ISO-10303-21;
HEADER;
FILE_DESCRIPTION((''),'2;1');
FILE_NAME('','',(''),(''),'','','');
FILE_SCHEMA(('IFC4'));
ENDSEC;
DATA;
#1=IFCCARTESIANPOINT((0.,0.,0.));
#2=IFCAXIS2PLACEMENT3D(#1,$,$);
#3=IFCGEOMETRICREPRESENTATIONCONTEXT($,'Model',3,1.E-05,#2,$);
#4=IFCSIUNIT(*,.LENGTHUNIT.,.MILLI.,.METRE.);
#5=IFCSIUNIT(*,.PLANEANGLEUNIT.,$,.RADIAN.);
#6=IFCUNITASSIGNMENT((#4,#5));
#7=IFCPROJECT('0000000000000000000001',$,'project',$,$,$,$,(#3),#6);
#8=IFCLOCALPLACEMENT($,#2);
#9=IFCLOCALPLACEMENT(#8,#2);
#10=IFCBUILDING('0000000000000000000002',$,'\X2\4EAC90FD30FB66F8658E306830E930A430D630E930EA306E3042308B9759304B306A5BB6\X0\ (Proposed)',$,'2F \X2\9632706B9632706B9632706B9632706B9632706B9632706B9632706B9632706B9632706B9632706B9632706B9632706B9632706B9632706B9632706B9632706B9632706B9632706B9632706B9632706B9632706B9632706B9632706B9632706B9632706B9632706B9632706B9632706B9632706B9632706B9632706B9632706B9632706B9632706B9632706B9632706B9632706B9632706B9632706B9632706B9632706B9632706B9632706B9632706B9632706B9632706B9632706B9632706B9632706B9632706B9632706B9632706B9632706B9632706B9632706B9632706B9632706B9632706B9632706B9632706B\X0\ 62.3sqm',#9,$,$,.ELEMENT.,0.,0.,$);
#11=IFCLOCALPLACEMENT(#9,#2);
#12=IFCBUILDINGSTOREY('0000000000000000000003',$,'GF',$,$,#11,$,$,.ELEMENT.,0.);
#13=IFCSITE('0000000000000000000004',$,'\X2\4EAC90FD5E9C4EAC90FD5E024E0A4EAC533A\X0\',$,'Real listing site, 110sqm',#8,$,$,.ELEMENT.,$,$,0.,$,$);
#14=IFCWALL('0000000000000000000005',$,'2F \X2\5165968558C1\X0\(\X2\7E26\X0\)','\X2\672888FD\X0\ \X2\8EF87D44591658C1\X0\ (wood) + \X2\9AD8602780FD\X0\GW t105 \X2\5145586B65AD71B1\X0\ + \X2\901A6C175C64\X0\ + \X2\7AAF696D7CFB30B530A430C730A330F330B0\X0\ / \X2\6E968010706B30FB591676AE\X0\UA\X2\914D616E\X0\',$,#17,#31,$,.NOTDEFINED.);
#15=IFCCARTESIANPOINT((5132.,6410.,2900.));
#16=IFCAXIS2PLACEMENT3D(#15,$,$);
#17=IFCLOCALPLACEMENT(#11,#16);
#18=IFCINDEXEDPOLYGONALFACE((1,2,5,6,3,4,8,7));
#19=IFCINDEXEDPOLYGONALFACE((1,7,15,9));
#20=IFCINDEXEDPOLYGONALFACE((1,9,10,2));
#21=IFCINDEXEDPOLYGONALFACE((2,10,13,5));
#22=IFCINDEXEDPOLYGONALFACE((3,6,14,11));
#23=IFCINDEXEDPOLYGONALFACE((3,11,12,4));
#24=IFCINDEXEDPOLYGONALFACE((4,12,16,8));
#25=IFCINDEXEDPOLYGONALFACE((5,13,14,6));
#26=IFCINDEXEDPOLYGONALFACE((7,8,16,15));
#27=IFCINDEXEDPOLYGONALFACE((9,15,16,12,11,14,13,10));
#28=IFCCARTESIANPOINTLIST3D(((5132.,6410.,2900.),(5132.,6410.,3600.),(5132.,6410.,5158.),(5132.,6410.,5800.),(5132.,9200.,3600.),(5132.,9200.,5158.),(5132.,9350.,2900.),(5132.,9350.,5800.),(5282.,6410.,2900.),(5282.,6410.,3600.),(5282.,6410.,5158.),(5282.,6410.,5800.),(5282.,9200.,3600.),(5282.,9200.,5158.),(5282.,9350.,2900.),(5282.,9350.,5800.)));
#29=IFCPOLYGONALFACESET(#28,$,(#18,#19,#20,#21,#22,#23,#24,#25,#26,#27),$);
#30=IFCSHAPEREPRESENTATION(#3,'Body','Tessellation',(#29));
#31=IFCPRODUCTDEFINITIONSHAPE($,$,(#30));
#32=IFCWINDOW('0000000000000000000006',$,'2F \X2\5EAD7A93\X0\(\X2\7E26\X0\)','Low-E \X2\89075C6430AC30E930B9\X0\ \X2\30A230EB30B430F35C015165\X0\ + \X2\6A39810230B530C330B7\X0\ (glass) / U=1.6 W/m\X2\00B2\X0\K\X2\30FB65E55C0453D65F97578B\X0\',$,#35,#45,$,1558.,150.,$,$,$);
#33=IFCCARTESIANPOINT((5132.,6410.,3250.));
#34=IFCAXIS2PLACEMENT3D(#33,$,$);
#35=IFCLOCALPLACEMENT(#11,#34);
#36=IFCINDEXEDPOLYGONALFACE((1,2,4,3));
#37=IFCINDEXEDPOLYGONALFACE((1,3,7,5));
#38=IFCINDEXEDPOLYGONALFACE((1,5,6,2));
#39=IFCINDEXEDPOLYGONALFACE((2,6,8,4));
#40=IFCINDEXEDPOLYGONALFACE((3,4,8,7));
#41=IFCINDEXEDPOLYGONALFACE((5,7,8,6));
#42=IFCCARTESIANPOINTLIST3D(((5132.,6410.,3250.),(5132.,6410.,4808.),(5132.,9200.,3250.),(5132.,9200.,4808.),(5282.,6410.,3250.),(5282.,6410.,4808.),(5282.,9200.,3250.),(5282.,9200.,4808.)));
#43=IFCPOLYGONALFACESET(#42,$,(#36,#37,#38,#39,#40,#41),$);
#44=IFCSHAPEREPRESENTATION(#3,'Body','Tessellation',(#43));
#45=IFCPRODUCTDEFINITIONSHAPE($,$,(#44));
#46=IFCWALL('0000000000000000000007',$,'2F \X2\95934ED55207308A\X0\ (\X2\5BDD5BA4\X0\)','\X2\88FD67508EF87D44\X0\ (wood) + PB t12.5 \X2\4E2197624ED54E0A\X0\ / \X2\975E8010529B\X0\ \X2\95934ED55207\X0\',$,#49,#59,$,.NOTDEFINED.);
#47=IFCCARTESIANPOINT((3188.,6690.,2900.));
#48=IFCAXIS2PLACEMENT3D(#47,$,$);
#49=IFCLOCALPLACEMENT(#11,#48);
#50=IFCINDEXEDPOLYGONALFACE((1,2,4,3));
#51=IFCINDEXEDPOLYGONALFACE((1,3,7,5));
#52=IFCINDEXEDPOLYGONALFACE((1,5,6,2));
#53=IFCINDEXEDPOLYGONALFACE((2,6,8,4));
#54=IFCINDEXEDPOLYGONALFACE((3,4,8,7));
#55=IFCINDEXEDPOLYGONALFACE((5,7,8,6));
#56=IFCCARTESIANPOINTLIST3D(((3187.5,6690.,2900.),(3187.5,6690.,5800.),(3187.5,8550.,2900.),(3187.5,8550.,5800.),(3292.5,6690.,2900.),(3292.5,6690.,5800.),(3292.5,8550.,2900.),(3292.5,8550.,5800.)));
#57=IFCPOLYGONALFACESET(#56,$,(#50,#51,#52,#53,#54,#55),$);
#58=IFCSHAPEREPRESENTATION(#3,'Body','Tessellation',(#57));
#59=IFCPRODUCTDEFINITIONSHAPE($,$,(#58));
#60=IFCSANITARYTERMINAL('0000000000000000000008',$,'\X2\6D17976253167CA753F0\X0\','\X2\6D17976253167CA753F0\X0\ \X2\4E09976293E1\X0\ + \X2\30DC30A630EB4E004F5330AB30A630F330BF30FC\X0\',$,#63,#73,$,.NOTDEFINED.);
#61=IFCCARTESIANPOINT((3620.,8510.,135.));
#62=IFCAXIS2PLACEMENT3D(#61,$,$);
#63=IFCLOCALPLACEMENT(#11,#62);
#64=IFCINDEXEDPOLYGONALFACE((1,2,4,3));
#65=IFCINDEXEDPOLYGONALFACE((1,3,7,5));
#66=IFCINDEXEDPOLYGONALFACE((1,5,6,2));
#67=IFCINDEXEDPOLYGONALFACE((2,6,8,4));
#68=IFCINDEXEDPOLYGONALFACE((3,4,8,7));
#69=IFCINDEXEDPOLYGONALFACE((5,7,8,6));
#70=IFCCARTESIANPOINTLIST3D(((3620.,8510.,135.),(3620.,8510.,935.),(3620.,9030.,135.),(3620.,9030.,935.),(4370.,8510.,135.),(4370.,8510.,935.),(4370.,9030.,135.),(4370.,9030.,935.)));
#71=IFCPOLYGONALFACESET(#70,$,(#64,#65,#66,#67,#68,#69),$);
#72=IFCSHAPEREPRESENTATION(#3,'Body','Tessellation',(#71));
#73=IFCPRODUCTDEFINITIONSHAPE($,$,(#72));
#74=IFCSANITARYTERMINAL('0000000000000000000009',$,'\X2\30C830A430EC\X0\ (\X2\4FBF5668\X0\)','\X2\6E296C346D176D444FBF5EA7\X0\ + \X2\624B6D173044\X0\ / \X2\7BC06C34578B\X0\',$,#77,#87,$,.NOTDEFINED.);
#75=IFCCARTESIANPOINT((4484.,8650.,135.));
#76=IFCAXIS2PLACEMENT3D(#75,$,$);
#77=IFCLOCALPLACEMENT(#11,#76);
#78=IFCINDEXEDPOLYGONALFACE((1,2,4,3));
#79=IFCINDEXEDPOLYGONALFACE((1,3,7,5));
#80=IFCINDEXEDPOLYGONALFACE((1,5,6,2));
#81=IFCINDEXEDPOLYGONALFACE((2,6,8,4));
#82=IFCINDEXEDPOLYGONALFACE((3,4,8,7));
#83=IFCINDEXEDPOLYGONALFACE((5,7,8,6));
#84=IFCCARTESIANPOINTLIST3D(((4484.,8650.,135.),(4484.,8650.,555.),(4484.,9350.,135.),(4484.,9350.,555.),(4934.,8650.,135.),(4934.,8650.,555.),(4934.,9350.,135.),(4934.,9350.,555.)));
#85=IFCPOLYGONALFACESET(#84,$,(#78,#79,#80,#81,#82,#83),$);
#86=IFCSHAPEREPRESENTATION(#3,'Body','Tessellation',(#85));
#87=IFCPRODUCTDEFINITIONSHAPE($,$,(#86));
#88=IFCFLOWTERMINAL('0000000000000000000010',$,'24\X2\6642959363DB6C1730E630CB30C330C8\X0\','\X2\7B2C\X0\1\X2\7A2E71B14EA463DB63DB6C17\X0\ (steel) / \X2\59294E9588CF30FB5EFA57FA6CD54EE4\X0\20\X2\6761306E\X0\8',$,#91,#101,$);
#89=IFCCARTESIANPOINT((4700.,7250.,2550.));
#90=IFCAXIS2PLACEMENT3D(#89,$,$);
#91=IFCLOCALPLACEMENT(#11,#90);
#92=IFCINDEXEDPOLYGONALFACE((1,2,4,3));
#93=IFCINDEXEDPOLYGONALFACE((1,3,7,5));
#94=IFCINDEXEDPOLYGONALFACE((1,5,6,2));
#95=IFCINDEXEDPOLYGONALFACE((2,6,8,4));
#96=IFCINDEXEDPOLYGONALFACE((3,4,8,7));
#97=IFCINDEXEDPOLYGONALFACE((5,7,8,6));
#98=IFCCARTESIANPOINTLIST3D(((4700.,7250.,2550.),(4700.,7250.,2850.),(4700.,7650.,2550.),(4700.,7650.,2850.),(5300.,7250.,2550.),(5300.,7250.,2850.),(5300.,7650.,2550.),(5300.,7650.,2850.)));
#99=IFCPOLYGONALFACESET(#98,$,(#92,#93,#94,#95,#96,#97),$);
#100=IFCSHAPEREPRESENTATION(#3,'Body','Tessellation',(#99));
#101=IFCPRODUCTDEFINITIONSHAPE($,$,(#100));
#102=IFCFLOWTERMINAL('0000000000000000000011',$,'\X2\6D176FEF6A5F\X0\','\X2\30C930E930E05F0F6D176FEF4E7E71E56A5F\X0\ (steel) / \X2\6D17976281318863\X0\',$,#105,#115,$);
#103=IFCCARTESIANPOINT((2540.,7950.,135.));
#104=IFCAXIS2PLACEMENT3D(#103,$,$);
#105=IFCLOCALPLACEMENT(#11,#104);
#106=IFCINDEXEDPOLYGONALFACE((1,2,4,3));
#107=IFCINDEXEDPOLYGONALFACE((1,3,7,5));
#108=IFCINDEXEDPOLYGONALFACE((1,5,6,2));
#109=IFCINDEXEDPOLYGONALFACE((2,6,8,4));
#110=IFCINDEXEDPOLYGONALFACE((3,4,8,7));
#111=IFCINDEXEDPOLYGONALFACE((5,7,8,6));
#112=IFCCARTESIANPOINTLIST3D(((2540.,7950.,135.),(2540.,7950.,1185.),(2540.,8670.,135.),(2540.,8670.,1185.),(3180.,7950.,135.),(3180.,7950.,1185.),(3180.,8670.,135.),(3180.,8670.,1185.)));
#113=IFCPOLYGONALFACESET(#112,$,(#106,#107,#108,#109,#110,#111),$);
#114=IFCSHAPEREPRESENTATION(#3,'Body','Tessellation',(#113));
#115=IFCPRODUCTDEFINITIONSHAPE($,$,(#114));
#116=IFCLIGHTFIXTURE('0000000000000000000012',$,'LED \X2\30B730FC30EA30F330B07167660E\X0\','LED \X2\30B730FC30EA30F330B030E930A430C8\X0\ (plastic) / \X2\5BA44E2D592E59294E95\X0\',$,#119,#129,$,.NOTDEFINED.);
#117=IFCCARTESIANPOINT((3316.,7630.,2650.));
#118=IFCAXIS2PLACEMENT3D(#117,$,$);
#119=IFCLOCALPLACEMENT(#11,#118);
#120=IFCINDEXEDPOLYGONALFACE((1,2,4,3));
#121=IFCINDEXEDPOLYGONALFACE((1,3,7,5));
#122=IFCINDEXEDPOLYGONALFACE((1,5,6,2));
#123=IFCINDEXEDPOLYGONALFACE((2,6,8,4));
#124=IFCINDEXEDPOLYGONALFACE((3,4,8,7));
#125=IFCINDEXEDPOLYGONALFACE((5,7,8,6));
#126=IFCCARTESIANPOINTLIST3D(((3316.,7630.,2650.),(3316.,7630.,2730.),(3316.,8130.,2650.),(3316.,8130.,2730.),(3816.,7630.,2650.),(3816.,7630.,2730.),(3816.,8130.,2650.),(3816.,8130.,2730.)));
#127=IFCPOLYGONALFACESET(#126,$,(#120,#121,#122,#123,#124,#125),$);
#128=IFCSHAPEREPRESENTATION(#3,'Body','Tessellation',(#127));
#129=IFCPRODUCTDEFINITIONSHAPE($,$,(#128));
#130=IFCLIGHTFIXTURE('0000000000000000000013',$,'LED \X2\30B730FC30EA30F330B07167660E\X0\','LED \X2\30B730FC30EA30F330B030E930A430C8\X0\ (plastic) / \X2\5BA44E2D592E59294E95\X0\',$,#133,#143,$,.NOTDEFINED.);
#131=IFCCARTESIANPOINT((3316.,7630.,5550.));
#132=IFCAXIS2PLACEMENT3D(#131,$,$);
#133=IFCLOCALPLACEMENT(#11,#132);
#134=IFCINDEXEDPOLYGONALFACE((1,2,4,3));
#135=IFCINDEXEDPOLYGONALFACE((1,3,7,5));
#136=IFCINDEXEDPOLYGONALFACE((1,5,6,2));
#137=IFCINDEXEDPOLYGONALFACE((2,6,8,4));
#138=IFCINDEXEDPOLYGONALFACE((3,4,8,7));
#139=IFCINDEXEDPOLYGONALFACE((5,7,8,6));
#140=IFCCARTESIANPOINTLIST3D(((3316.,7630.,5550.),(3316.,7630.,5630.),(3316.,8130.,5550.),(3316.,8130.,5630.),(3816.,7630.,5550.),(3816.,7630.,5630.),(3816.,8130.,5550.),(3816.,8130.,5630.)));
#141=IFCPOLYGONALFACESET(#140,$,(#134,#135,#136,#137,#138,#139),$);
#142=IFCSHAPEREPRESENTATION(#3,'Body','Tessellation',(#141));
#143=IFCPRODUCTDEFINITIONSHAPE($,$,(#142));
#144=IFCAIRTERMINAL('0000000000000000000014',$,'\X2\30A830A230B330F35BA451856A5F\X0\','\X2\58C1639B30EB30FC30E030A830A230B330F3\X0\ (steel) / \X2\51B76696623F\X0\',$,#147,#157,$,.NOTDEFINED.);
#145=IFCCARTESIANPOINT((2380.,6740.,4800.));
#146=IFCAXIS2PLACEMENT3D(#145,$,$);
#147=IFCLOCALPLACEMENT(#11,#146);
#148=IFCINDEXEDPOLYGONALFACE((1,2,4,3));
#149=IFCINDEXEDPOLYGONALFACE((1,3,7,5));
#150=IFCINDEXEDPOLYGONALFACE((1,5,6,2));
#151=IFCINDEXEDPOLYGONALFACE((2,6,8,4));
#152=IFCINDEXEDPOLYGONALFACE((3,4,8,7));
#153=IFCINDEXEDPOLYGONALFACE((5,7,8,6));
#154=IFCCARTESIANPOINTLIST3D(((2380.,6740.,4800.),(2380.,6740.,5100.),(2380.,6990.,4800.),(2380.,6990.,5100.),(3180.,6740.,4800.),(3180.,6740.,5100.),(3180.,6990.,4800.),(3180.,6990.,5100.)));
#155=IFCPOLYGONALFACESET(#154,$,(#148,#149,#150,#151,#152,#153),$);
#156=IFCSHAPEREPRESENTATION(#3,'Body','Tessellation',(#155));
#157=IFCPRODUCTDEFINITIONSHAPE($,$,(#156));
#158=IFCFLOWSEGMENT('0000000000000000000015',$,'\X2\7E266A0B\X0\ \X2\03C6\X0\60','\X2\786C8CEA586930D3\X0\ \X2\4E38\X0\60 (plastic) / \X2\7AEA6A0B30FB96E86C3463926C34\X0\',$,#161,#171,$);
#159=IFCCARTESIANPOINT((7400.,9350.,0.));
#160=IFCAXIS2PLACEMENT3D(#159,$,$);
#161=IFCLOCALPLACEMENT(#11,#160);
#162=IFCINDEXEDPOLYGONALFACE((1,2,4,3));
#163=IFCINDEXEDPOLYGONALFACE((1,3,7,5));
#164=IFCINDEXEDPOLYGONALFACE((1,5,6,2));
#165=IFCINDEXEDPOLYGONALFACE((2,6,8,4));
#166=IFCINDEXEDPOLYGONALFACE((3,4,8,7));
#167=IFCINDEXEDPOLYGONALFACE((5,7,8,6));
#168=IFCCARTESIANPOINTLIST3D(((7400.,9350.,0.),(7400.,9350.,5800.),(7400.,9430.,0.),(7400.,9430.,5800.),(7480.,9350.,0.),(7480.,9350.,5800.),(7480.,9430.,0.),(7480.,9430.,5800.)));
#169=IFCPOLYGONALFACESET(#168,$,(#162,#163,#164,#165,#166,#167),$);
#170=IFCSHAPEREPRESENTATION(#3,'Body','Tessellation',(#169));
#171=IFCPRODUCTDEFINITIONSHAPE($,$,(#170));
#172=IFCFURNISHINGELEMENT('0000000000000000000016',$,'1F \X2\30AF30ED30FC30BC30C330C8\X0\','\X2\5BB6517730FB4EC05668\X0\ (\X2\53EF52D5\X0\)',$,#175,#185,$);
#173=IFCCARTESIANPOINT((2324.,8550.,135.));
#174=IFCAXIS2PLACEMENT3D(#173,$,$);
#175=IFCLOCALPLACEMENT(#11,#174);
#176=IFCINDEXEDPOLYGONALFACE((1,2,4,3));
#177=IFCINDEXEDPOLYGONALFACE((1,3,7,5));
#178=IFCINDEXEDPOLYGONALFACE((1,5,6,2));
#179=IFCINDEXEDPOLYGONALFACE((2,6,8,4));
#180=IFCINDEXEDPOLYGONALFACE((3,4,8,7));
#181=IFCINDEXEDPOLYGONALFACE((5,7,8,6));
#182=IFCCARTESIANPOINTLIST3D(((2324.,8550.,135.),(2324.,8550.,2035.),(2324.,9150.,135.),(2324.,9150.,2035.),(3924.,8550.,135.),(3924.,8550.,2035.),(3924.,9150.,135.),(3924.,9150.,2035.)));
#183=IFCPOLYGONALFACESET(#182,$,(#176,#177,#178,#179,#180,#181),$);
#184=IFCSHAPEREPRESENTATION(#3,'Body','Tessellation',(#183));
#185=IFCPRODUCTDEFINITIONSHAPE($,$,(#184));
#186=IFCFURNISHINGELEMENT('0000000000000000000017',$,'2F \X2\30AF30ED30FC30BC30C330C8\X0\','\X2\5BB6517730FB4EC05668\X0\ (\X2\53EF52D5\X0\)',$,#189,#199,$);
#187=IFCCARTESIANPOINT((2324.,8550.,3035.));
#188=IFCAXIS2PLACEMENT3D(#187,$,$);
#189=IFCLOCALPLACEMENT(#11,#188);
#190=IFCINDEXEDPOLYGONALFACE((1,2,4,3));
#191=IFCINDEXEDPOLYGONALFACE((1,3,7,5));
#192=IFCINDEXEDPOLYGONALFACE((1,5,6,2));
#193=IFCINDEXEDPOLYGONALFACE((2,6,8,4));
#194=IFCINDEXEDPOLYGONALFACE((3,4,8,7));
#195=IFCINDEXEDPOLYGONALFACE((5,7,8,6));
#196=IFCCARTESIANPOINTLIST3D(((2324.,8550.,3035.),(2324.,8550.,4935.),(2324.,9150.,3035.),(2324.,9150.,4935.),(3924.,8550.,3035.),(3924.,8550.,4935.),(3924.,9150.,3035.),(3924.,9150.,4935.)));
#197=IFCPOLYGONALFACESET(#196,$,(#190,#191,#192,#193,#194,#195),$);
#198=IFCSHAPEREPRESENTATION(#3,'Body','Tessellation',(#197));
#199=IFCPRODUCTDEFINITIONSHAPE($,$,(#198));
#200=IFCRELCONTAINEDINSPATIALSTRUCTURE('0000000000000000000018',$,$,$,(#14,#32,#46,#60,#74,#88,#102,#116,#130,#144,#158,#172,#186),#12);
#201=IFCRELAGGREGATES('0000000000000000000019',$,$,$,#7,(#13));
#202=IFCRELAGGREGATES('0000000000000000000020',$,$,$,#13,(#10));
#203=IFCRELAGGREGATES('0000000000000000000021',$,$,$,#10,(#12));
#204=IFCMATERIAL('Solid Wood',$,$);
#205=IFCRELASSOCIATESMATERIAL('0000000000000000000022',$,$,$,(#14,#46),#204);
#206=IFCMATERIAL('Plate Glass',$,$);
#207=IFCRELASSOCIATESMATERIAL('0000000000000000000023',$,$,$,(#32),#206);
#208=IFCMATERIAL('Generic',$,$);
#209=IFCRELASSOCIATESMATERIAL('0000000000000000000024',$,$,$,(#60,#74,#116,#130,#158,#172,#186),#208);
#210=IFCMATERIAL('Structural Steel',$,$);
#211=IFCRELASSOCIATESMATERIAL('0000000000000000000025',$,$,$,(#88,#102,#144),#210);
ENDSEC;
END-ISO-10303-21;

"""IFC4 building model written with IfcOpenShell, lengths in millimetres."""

from ifc_helpers import new_model, si_unit, frame, frame_2d, origin, place, context, project, spatial, rectangle, extrude, material, element, fill, save


model = new_model("IFC4")

# Units and contexts
model_context = context("Model", 3, precision=1e-05, world=origin())
ifc_project = project(units=[si_unit("LENGTHUNIT", "METRE", prefix="MILLI"), si_unit("PLANEANGLEUNIT", "RADIAN")], contexts=[model_context])

# Site, building, storey
site_placement = place(None, origin())
site = spatial("IfcSite", under=ifc_project, at=site_placement, Name="京都府京都市上京区", ObjectType="Real listing site, 110sqm", CompositionType="ELEMENT", RefElevation=0.0)
building_placement = place(site_placement, origin())
building = spatial("IfcBuilding", under=site, at=building_placement, Name="京都・書斎とライブラリのある静かな家 (Proposed)", ObjectType="2F 防火防火防火防火防火防火防火防火防火防火防火防火防火防火防火防火防火防火防火防火防火防火防火防火防火防火防火防火防火防火防火防火防火防火防火防火防火防火防火防火防火防火防火防火防火防火防火防火防火防火防火防火防火防火防火防火防火防火防火防火 62.3sqm", CompositionType="ELEMENT", ElevationOfRefHeight=0.0, ElevationOfTerrain=0.0)
storey_placement = place(building_placement, origin())
storey = spatial("IfcBuildingStorey", under=building, at=storey_placement, Name="GF", CompositionType="ELEMENT", Elevation=0.0)

# Shared definitions
ifc_material_1 = material(Name="Solid Wood")

# Shared definitions
ifc_material_2 = material(Name="Plate Glass")

# Wall, opening, window
wall_1_placement = place(storey_placement, frame((5132.0, 6410.0, 2900.0)))
wall_1 = element("IfcWall", 1, at=wall_1_placement, inside=storey, material=ifc_material_1, Name="2F 入隅壁(縦)", Description="木製 軸組外壁 (wood) + 高性能GW t105 充填断熱 + 通気層 + 窯業系サイディング / 準耐火・外皮UA配慮", PredefinedType="NOTDEFINED", context=model_context, shape_type="SweptSolid", body=[
    extrude(rectangle(XDim=150.0, YDim=2940.0, at=frame_2d((75.0, 1470.0))), frame((5132.0, 6410.0, 2900.0)), (0.0, 0.0, 1.0), 2900.0),
])
opening_1_placement = place(storey_placement, frame((5132.0, 6410.0, 3250.0)))
opening_1 = element("IfcOpeningElement", 2, at=opening_1_placement, cuts=wall_1, PredefinedType="NOTDEFINED", context=model_context, shape_type="SweptSolid", body=[
    extrude(rectangle(XDim=150.0, YDim=2790.0, at=frame_2d((75.0, 1395.0))), frame((5132.0, 6410.0, 3250.0)), (0.0, 0.0, 1.0), 1558.0),
])
window_1_placement = place(storey_placement, frame((5132.0, 6410.0, 3250.0)))
window_1 = element("IfcWindow", 3, at=window_1_placement, inside=storey, material=ifc_material_2, Name="2F 庭窓(縦)", Description="Low-E 複層ガラス アルゴン封入 + 樹脂サッシ (glass) / U=1.6 W/m²K・日射取得型", OverallHeight=1558.0, OverallWidth=150.0, context=model_context, shape_type="SweptSolid", body=[
    extrude(rectangle(XDim=150.0, YDim=2790.0, at=frame_2d((75.0, 1395.0))), frame((5132.0, 6410.0, 3250.0)), (0.0, 0.0, 1.0), 1558.0),
])
fill(opening_1, window_1)

# Wall
wall_2_placement = place(storey_placement, frame((3188.0, 6690.0, 2900.0)))
element("IfcWall", 4, at=wall_2_placement, inside=storey, material=ifc_material_1, Name="2F 間仕切り (寝室)", Description="製材軸組 (wood) + PB t12.5 両面仕上 / 非耐力 間仕切", PredefinedType="NOTDEFINED", context=model_context, shape_type="SweptSolid", body=[
    extrude(rectangle(XDim=105.0, YDim=1860.0, at=frame_2d((52.0, 930.0))), frame((3188.0, 6690.0, 2900.0)), (0.0, 0.0, 1.0), 2900.0),
])

# Sanitary terminals
ifc_material_3 = material(Name="Generic")
sanitary_terminal_1_placement = place(storey_placement, frame((3620.0, 8510.0, 135.0)))
element("IfcSanitaryTerminal", 5, at=sanitary_terminal_1_placement, inside=storey, material=ifc_material_3, Name="洗面化粧台", Description="洗面化粧台 三面鏡 + ボウル一体カウンター", PredefinedType="NOTDEFINED", context=model_context, shape_type="SweptSolid", body=[
    extrude(rectangle(XDim=750.0, YDim=520.0, at=frame_2d((375.0, 260.0))), frame((3620.0, 8510.0, 135.0)), (0.0, 0.0, 1.0), 800.0),
])
sanitary_terminal_2_placement = place(storey_placement, frame((4484.0, 8650.0, 135.0)))
element("IfcSanitaryTerminal", 6, at=sanitary_terminal_2_placement, inside=storey, material=ifc_material_3, Name="トイレ (便器)", Description="温水洗浄便座 + 手洗い / 節水型", PredefinedType="NOTDEFINED", context=model_context, shape_type="SweptSolid", body=[
    extrude(rectangle(XDim=450.0, YDim=700.0, at=frame_2d((225.0, 350.0))), frame((4484.0, 8650.0, 135.0)), (0.0, 0.0, 1.0), 420.0),
])

# Flow terminals
ifc_material_4 = material(Name="Structural Steel")
flow_terminal_1_placement = place(storey_placement, frame((4700.0, 7250.0, 2550.0)))
element("IfcFlowTerminal", 7, at=flow_terminal_1_placement, inside=storey, material=ifc_material_4, Name="24時間換気ユニット", Description="第1種熱交換換気 (steel) / 天井裏・建基法令20条の8", context=model_context, shape_type="SweptSolid", body=[
    extrude(rectangle(XDim=600.0, YDim=400.0, at=frame_2d((300.0, 200.0))), frame((4700.0, 7250.0, 2550.0)), (0.0, 0.0, 1.0), 300.0),
])
flow_terminal_2_placement = place(storey_placement, frame((2540.0, 7950.0, 135.0)))
element("IfcFlowTerminal", 8, at=flow_terminal_2_placement, inside=storey, material=ifc_material_4, Name="洗濯機", Description="ドラム式洗濯乾燥機 (steel) / 洗面脱衣", context=model_context, shape_type="SweptSolid", body=[
    extrude(rectangle(XDim=640.0, YDim=720.0, at=frame_2d((320.0, 360.0))), frame((2540.0, 7950.0, 135.0)), (0.0, 0.0, 1.0), 1050.0),
])

# Light fixtures
light_fixture_1_placement = place(storey_placement, frame((3316.0, 7630.0, 2650.0)))
element("IfcLightFixture", 9, at=light_fixture_1_placement, inside=storey, material=ifc_material_3, Name="LED シーリング照明", Description="LED シーリングライト (plastic) / 室中央天井", PredefinedType="NOTDEFINED", context=model_context, shape_type="SweptSolid", body=[
    extrude(rectangle(XDim=500.0, YDim=500.0, at=frame_2d((250.0, 250.0))), frame((3316.0, 7630.0, 2650.0)), (0.0, 0.0, 1.0), 80.0),
])
light_fixture_2_placement = place(storey_placement, frame((3316.0, 7630.0, 5550.0)))
element("IfcLightFixture", 10, at=light_fixture_2_placement, inside=storey, material=ifc_material_3, Name="LED シーリング照明", Description="LED シーリングライト (plastic) / 室中央天井", PredefinedType="NOTDEFINED", context=model_context, shape_type="SweptSolid", body=[
    extrude(rectangle(XDim=500.0, YDim=500.0, at=frame_2d((250.0, 250.0))), frame((3316.0, 7630.0, 5550.0)), (0.0, 0.0, 1.0), 80.0),
])

# Air terminal
air_terminal_placement = place(storey_placement, frame((2380.0, 6740.0, 4800.0)))
element("IfcAirTerminal", 11, at=air_terminal_placement, inside=storey, material=ifc_material_4, Name="エアコン室内機", Description="壁掛ルームエアコン (steel) / 冷暖房", PredefinedType="NOTDEFINED", context=model_context, shape_type="SweptSolid", body=[
    extrude(rectangle(XDim=800.0, YDim=250.0, at=frame_2d((400.0, 125.0))), frame((2380.0, 6740.0, 4800.0)), (0.0, 0.0, 1.0), 300.0),
])

# Flow segment
flow_segment_placement = place(storey_placement, frame((7400.0, 9350.0, 0.0)))
element("IfcFlowSegment", 12, at=flow_segment_placement, inside=storey, material=ifc_material_3, Name="縦樋 φ60", Description="硬質塩ビ 丸60 (plastic) / 竪樋・雨水排水", context=model_context, shape_type="SweptSolid", body=[
    extrude(rectangle(XDim=80.0, YDim=80.0, at=frame_2d((40.0, 40.0))), frame((7400.0, 9350.0, 0.0)), (0.0, 0.0, 1.0), 5800.0),
])

# Furnishing elements
furnishing_1_placement = place(storey_placement, frame((2324.0, 8550.0, 135.0)))
element("IfcFurnishingElement", 13, at=furnishing_1_placement, inside=storey, material=ifc_material_3, Name="1F クローゼット", Description="家具・什器 (可動)", context=model_context, shape_type="SweptSolid", body=[
    extrude(rectangle(XDim=1600.0, YDim=600.0, at=frame_2d((800.0, 300.0))), frame((2324.0, 8550.0, 135.0)), (0.0, 0.0, 1.0), 1900.0),
])
furnishing_2_placement = place(storey_placement, frame((2324.0, 8550.0, 3035.0)))
element("IfcFurnishingElement", 14, at=furnishing_2_placement, inside=storey, material=ifc_material_3, Name="2F クローゼット", Description="家具・什器 (可動)", context=model_context, shape_type="SweptSolid", body=[
    extrude(rectangle(XDim=1600.0, YDim=600.0, at=frame_2d((800.0, 300.0))), frame((2324.0, 8550.0, 3035.0)), (0.0, 0.0, 1.0), 1900.0),
])

save(model, "model.ifc")
